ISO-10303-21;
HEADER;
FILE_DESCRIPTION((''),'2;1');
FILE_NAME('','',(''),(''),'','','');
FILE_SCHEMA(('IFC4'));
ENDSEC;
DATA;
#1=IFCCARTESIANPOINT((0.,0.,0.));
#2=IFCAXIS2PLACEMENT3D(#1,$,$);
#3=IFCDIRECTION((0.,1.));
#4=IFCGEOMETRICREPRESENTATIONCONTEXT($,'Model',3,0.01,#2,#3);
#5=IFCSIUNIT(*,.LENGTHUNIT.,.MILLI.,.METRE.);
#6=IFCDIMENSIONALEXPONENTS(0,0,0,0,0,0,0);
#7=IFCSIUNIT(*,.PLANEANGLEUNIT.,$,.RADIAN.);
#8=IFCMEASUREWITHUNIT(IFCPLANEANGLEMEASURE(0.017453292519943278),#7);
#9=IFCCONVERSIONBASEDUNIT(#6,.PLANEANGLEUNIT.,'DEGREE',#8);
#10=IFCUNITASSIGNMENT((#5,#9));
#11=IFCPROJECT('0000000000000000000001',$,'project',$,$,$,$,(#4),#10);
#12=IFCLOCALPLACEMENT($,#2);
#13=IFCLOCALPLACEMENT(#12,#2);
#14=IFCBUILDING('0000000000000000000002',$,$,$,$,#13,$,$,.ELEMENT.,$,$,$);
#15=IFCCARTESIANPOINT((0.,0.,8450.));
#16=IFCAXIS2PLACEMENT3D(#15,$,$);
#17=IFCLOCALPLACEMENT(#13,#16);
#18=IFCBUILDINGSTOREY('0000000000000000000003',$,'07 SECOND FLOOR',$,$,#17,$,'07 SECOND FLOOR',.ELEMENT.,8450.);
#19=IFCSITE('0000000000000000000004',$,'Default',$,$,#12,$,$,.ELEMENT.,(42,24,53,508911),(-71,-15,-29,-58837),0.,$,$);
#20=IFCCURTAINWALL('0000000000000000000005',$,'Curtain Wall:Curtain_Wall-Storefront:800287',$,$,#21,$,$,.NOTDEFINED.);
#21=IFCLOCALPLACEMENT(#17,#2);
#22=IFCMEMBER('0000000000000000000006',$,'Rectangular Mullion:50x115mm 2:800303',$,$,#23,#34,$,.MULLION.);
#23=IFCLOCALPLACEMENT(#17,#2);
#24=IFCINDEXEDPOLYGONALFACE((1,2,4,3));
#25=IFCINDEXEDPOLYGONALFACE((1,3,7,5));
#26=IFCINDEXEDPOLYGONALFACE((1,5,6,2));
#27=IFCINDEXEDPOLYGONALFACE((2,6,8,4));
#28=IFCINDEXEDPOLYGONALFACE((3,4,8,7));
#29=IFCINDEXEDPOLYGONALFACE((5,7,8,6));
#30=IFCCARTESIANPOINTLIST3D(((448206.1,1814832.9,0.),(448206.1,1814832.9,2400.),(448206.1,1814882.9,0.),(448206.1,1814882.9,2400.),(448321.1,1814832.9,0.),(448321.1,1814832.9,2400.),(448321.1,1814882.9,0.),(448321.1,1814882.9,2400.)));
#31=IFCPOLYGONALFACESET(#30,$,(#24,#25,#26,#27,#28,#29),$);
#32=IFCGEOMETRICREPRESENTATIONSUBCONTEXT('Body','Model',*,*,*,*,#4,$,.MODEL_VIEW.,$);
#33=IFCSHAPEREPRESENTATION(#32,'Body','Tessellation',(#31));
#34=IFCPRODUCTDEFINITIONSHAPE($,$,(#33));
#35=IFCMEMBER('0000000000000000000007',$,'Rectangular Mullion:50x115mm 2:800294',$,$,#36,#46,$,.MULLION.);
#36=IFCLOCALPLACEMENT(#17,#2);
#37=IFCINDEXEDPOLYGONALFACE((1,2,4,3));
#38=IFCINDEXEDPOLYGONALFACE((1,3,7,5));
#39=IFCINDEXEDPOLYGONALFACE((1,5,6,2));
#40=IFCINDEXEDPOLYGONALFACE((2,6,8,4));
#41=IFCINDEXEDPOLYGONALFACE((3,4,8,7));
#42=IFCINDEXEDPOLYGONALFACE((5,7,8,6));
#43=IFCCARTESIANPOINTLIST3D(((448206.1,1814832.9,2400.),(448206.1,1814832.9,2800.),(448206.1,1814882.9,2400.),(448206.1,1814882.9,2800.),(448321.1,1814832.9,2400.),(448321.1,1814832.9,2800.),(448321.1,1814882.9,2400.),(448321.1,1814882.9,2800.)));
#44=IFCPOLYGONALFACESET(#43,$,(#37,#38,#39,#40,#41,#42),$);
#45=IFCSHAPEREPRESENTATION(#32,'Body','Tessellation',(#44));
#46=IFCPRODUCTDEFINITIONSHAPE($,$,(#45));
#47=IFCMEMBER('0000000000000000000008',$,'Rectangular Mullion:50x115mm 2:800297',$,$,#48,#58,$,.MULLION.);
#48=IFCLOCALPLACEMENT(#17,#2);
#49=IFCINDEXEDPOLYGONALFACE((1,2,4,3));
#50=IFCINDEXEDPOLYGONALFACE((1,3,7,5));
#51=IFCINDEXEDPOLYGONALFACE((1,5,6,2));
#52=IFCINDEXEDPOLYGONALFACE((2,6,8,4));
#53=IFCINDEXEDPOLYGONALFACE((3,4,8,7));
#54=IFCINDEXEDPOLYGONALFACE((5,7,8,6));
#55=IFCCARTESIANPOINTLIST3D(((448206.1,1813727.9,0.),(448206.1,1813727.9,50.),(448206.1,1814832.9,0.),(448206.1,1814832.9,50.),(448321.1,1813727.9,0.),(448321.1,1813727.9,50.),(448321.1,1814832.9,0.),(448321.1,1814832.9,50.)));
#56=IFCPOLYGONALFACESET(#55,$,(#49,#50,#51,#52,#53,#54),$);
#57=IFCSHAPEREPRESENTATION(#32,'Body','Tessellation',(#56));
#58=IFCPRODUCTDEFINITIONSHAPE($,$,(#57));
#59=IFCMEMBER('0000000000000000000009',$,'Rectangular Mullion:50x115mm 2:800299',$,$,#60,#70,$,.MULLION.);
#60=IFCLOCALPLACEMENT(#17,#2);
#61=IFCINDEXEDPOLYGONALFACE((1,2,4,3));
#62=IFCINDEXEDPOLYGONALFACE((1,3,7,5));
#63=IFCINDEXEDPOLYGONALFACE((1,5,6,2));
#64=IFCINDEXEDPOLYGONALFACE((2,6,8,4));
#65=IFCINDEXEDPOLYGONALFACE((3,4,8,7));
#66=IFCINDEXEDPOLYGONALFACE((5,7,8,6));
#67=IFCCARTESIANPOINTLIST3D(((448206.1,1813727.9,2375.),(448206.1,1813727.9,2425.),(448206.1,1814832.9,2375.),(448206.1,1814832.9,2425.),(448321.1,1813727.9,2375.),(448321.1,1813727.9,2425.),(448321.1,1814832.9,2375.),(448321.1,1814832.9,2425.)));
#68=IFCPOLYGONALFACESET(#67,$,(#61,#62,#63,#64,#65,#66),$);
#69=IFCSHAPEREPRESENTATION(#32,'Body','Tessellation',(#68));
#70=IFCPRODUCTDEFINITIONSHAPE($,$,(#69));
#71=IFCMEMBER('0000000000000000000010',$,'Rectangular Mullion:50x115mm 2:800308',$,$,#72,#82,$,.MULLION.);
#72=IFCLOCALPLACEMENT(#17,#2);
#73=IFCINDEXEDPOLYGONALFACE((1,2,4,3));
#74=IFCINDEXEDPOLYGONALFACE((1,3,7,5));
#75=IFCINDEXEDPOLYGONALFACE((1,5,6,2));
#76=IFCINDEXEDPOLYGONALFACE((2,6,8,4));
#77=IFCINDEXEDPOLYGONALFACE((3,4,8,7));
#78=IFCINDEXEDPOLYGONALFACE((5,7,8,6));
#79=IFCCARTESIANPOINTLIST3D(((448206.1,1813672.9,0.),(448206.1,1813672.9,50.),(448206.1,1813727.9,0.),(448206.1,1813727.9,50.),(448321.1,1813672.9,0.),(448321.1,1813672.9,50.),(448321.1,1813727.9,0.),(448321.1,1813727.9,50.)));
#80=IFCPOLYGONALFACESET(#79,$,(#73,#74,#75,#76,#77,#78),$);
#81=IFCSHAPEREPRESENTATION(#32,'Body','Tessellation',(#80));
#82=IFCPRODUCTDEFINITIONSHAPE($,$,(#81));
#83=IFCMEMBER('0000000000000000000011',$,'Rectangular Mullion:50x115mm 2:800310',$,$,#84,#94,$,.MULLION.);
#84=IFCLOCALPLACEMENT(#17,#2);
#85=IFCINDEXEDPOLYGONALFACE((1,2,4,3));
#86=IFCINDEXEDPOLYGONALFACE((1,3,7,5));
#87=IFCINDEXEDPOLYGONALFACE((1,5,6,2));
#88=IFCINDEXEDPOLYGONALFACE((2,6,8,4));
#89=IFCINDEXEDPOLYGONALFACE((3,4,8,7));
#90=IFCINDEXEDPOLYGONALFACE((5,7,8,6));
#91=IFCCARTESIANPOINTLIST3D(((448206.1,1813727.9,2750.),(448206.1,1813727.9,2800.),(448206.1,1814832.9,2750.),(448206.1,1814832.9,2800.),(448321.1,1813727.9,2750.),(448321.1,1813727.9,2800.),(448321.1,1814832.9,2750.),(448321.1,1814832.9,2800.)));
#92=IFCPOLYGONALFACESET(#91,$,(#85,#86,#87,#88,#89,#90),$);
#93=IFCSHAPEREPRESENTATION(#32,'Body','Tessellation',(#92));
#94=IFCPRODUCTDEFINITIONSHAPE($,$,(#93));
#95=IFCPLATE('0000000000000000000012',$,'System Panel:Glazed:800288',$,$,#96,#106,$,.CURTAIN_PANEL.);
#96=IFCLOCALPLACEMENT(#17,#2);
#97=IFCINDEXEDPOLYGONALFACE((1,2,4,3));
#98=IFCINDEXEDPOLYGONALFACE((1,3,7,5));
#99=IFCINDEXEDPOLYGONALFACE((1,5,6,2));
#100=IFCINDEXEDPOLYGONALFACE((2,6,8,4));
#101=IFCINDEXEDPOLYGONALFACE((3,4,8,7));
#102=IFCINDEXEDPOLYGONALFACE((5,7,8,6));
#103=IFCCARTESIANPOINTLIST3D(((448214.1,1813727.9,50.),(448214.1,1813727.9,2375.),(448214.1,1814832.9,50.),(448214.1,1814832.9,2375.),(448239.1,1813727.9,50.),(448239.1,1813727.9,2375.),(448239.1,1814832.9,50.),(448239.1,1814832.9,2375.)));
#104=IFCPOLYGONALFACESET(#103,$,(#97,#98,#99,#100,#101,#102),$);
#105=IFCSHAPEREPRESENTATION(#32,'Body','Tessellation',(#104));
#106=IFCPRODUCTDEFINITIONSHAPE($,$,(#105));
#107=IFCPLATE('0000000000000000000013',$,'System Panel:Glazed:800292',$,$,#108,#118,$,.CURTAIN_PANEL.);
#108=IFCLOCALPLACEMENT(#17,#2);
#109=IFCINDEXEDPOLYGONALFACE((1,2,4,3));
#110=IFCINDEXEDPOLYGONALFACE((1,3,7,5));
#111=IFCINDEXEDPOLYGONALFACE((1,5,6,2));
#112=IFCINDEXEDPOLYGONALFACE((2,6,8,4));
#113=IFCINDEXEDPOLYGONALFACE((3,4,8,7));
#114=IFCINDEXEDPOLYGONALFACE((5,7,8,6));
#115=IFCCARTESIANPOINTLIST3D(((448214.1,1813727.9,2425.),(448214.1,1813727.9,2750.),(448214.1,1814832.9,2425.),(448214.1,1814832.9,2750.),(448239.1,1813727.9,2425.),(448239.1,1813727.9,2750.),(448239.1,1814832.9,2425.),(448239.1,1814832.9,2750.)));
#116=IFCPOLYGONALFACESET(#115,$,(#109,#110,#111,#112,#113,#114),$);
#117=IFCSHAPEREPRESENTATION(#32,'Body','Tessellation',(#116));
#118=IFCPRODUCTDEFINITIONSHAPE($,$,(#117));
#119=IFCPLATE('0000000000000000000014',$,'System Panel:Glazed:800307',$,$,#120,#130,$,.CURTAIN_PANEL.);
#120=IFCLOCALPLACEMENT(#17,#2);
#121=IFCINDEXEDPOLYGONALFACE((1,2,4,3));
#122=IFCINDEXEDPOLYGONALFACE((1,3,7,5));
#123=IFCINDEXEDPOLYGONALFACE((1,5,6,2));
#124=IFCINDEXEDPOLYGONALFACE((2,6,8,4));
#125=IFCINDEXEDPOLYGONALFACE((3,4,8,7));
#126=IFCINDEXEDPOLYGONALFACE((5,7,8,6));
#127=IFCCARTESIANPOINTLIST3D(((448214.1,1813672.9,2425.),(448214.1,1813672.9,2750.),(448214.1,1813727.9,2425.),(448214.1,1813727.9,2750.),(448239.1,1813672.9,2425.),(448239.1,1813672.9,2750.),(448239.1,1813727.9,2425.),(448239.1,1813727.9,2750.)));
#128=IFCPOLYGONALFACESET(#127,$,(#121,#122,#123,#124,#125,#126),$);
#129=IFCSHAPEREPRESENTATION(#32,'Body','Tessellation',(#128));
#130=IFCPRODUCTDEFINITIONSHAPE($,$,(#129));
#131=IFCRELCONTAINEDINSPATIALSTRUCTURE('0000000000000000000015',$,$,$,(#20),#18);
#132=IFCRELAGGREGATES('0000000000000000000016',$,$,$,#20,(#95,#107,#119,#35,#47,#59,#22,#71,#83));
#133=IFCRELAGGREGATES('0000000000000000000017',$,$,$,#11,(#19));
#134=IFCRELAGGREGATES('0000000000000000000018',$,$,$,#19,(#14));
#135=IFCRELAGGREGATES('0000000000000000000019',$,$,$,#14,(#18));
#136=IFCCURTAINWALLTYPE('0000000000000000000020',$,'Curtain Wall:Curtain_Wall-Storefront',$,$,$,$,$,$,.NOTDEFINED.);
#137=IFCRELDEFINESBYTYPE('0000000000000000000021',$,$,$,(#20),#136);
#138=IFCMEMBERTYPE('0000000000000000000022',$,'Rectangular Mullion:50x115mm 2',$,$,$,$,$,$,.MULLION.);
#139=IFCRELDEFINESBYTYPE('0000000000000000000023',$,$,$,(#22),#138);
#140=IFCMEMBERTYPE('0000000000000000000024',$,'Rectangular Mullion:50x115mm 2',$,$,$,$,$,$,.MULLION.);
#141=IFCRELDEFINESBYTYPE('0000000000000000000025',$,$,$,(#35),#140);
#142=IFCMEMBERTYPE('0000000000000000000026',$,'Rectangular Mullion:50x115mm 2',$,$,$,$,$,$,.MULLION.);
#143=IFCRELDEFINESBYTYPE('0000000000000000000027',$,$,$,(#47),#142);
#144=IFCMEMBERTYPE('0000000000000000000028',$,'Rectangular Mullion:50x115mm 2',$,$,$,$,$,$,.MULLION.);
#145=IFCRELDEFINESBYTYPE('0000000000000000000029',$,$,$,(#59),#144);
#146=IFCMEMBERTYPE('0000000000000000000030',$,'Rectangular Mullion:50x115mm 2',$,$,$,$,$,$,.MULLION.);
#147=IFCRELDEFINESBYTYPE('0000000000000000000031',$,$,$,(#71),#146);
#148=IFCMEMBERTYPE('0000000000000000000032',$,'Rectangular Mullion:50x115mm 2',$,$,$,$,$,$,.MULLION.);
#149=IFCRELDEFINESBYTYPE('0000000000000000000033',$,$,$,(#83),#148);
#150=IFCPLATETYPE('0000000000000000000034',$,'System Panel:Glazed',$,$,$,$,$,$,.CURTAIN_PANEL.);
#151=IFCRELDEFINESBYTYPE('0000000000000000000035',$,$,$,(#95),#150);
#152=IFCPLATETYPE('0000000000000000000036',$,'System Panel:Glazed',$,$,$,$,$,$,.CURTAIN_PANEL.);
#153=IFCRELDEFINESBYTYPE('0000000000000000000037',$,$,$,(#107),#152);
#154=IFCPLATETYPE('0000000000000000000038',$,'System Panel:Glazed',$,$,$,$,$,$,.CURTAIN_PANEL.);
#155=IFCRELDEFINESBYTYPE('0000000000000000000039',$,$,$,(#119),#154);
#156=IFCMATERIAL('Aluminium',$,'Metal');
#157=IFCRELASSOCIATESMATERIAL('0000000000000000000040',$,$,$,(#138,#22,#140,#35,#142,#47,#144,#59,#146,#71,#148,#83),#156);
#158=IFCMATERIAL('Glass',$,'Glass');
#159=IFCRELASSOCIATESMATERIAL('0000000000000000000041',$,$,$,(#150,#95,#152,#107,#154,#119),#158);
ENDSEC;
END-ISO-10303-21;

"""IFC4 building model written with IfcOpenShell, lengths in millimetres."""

from ifc_helpers import new_model, entity, si_unit, converted_unit, direction, frame, origin, place, context, subcontext, project, spatial, indexed_curve, outline, extrude, source, transform, mapped, material, type_object, type_shapes, element, aggregate, save


model = new_model("IFC4")

# Units and contexts
model_context = context("Model", 3, precision=0.01, world=origin(), true_north=direction((0.0, 1.0)))
body_context = subcontext(model_context, "Body", "Model", "MODEL_VIEW")
ifc_project = project(units=[si_unit("LENGTHUNIT", "METRE", prefix="MILLI"), converted_unit("PLANEANGLEUNIT", "DEGREE", entity("IfcPlaneAngleMeasure", 0.017453292519943278), si_unit("PLANEANGLEUNIT", "RADIAN"), dimensions=[0, 0, 0, 0, 0, 0, 0])], contexts=[model_context])

# Site, building, storey
site_placement = place(None, origin())
site = spatial("IfcSite", under=ifc_project, at=site_placement, Name="Default", CompositionType="ELEMENT", RefLatitude=(42, 24, 53, 508911), RefLongitude=(-71, -15, -29, -58837), RefElevation=0.0)
building_placement = place(site_placement, origin())
building = spatial("IfcBuilding", under=site, at=building_placement, CompositionType="ELEMENT")
storey_placement = place(building_placement, frame((0.0, 0.0, 8450.0)))
storey = spatial("IfcBuildingStorey", under=building, at=storey_placement, Name="07 SECOND FLOOR", LongName="07 SECOND FLOOR", CompositionType="ELEMENT", Elevation=8450.0)

# Curtain wall, members, plates
curtain_wall_type = type_object("IfcCurtainWallType", Name="Curtain Wall:Curtain_Wall-Storefront", PredefinedType="NOTDEFINED")
curtain_wall_placement = place(storey_placement, frame((0.0, 0.0, -8450.0)))
curtain_wall = element("IfcCurtainWall", 1, at=curtain_wall_placement, inside=storey, type_object=curtain_wall_type, Name="Curtain Wall:Curtain_Wall-Storefront:800287", PredefinedType="NOTDEFINED")
ifc_material_1 = material(Name="Aluminium", Category="Metal")
member_type_1 = type_object("IfcMemberType", Name="Rectangular Mullion:50x115mm 2", PredefinedType="MULLION", material=ifc_material_1)
shared_shape_1 = source(origin(), body_context, "Body", "SweptSolid", [
    extrude(outline(indexed_curve([(-25.0, -57.5), (25.0, -57.5), (25.0, 57.5), (-25.0, 57.5), (-25.0, -57.5)], self_intersect=False)), frame((-25.0, 0.0, -2400.0), z_axis=(0.0, 0.0, 1.0), x_axis=(-1.0, 0.0, 0.0)), (0.0, 0.0, 1.0), 2400.0),
])
type_shapes(member_type_1, [shared_shape_1])
member_1_placement = place(curtain_wall_placement, frame((448263.6, 1814882.9, 10850.0), z_axis=(0.0, 0.0, 1.0), x_axis=(0.0, 1.0, 0.0)))
member_1 = element("IfcMember", 2, at=member_1_placement, type_object=member_type_1, material=ifc_material_1, Name="Rectangular Mullion:50x115mm 2:800303", PredefinedType="MULLION", context=body_context, shape_type="MappedRepresentation", body=[
    mapped(shared_shape_1, transform((0.0, 0.0, 0.0), scale=1.0)),
])
member_type_2 = type_object("IfcMemberType", Name="Rectangular Mullion:50x115mm 2", PredefinedType="MULLION", material=ifc_material_1)
shared_shape_2 = source(origin(), body_context, "Body", "SweptSolid", [
    extrude(outline(indexed_curve([(-25.0, -57.5), (25.0, -57.5), (25.0, 57.5), (-25.0, 57.5), (-25.0, -57.5)], self_intersect=False)), frame((-25.0, 0.0, -400.0), z_axis=(0.0, 0.0, 1.0), x_axis=(-1.0, 0.0, 0.0)), (0.0, 0.0, 1.0), 400.0),
])
type_shapes(member_type_2, [shared_shape_2])
member_2_placement = place(curtain_wall_placement, frame((448263.6, 1814882.9, 11250.0), z_axis=(0.0, 0.0, 1.0), x_axis=(0.0, 1.0, 0.0)))
member_2 = element("IfcMember", 3, at=member_2_placement, type_object=member_type_2, material=ifc_material_1, Name="Rectangular Mullion:50x115mm 2:800294", PredefinedType="MULLION", context=body_context, shape_type="MappedRepresentation", body=[
    mapped(shared_shape_2, transform((0.0, 0.0, 0.0), scale=1.0)),
])
member_type_3 = type_object("IfcMemberType", Name="Rectangular Mullion:50x115mm 2", PredefinedType="MULLION", material=ifc_material_1)
shared_shape_3 = source(origin(), body_context, "Body", "SweptSolid", [
    extrude(outline(indexed_curve([(-25.0, -57.5), (25.0, -57.5), (25.0, 57.5), (-25.0, 57.5), (-25.0, -57.5)], self_intersect=False)), frame((-25.0, 0.0, -1105.0), z_axis=(0.0, 0.0, 1.0), x_axis=(-1.0, 0.0, 0.0)), (0.0, 0.0, 1.0), 1105.0),
])
type_shapes(member_type_3, [shared_shape_3])
member_3_placement = place(curtain_wall_placement, frame((448263.6, 1814832.9, 8450.0), z_axis=(0.0, 1.0, 0.0), x_axis=(0.0, 0.0, -1.0)))
member_3 = element("IfcMember", 4, at=member_3_placement, type_object=member_type_3, material=ifc_material_1, Name="Rectangular Mullion:50x115mm 2:800297", PredefinedType="MULLION", context=body_context, shape_type="MappedRepresentation", body=[
    mapped(shared_shape_3, transform((0.0, 0.0, 0.0), scale=1.0)),
])
member_type_4 = type_object("IfcMemberType", Name="Rectangular Mullion:50x115mm 2", PredefinedType="MULLION", material=ifc_material_1)
shared_shape_4 = source(origin(), body_context, "Body", "SweptSolid", [
    extrude(outline(indexed_curve([(-25.0, -57.5), (25.0, -57.5), (25.0, 57.5), (-25.0, 57.5), (-25.0, -57.5)], self_intersect=False)), frame((0.0, 0.0, -1105.0), z_axis=(0.0, 0.0, 1.0), x_axis=(-1.0, 0.0, 0.0)), (0.0, 0.0, 1.0), 1105.0),
])
type_shapes(member_type_4, [shared_shape_4])
member_4_placement = place(curtain_wall_placement, frame((448263.6, 1813727.9, 10850.0), z_axis=(0.0, -1.0, 0.0), x_axis=(0.0, 0.0, 1.0)))
member_4 = element("IfcMember", 5, at=member_4_placement, type_object=member_type_4, material=ifc_material_1, Name="Rectangular Mullion:50x115mm 2:800299", PredefinedType="MULLION", context=body_context, shape_type="MappedRepresentation", body=[
    mapped(shared_shape_4, transform((0.0, 0.0, 0.0), scale=1.0)),
])
member_type_5 = type_object("IfcMemberType", Name="Rectangular Mullion:50x115mm 2", PredefinedType="MULLION", material=ifc_material_1)
shared_shape_5 = source(origin(), body_context, "Body", "SweptSolid", [
    extrude(outline(indexed_curve([(-25.0, -57.5), (25.0, -57.5), (25.0, 57.5), (-25.0, 57.5), (-25.0, -57.5)], self_intersect=False)), frame((-25.0, 0.0, -55.0), z_axis=(0.0, 0.0, 1.0), x_axis=(-1.0, 0.0, 0.0)), (0.0, 0.0, 1.0), 55.0),
])
type_shapes(member_type_5, [shared_shape_5])
member_5_placement = place(curtain_wall_placement, frame((448263.6, 1813727.9, 8450.0), z_axis=(0.0, 1.0, 0.0), x_axis=(0.0, 0.0, -1.0)))
member_5 = element("IfcMember", 6, at=member_5_placement, type_object=member_type_5, material=ifc_material_1, Name="Rectangular Mullion:50x115mm 2:800308", PredefinedType="MULLION", context=body_context, shape_type="MappedRepresentation", body=[
    mapped(shared_shape_5, transform((0.0, 0.0, 0.0), scale=1.0)),
])
member_type_6 = type_object("IfcMemberType", Name="Rectangular Mullion:50x115mm 2", PredefinedType="MULLION", material=ifc_material_1)
shared_shape_6 = source(origin(), body_context, "Body", "SweptSolid", [
    extrude(outline(indexed_curve([(-25.0, -57.5), (25.0, -57.5), (25.0, 57.5), (-25.0, 57.5), (-25.0, -57.5)], self_intersect=False)), frame((-25.0, 0.0, -1105.0), z_axis=(0.0, 0.0, 1.0), x_axis=(-1.0, 0.0, 0.0)), (0.0, 0.0, 1.0), 1105.0),
])
type_shapes(member_type_6, [shared_shape_6])
member_6_placement = place(curtain_wall_placement, frame((448263.6, 1813727.9, 11250.0), z_axis=(0.0, -1.0, 0.0), x_axis=(0.0, 0.0, 1.0)))
member_6 = element("IfcMember", 7, at=member_6_placement, type_object=member_type_6, material=ifc_material_1, Name="Rectangular Mullion:50x115mm 2:800310", PredefinedType="MULLION", context=body_context, shape_type="MappedRepresentation", body=[
    mapped(shared_shape_6, transform((0.0, 0.0, 0.0), scale=1.0)),
])
ifc_material_2 = material(Name="Glass", Category="Glass")
plate_type_1 = type_object("IfcPlateType", Name="System Panel:Glazed", PredefinedType="CURTAIN_PANEL", material=ifc_material_2)
shared_shape_7 = source(origin(), body_context, "Body", "SweptSolid", [
    extrude(outline(indexed_curve([(-12.5, -552.5), (12.5, -552.5), (12.5, 552.5), (-12.5, 552.5), (-12.5, -552.5)], self_intersect=False)), frame((0.0, -37.0, 0.0), z_axis=(0.0, 0.0, 1.0), x_axis=(0.0, 1.0, 0.0)), (0.0, 0.0, 1.0), 2325.0),
])
type_shapes(plate_type_1, [shared_shape_7])
plate_1_placement = place(curtain_wall_placement, frame((448263.6, 1814280.4, 8500.0), z_axis=(0.0, 0.0, 1.0), x_axis=(0.0, -1.0, 0.0)))
plate_1 = element("IfcPlate", 8, at=plate_1_placement, type_object=plate_type_1, material=ifc_material_2, Name="System Panel:Glazed:800288", PredefinedType="CURTAIN_PANEL", context=body_context, shape_type="MappedRepresentation", body=[
    mapped(shared_shape_7, transform((0.0, 0.0, 0.0), scale=1.0)),
])
plate_type_2 = type_object("IfcPlateType", Name="System Panel:Glazed", PredefinedType="CURTAIN_PANEL", material=ifc_material_2)
shared_shape_8 = source(origin(), body_context, "Body", "SweptSolid", [
    extrude(outline(indexed_curve([(-12.5, -552.5), (12.5, -552.5), (12.5, 552.5), (-12.5, 552.5), (-12.5, -552.5)], self_intersect=False)), frame((0.0, -37.0, 0.0), z_axis=(0.0, 0.0, 1.0), x_axis=(0.0, 1.0, 0.0)), (0.0, 0.0, 1.0), 325.0),
])
type_shapes(plate_type_2, [shared_shape_8])
plate_2_placement = place(curtain_wall_placement, frame((448263.6, 1814280.4, 10875.0), z_axis=(0.0, 0.0, 1.0), x_axis=(0.0, -1.0, 0.0)))
plate_2 = element("IfcPlate", 9, at=plate_2_placement, type_object=plate_type_2, material=ifc_material_2, Name="System Panel:Glazed:800292", PredefinedType="CURTAIN_PANEL", context=body_context, shape_type="MappedRepresentation", body=[
    mapped(shared_shape_8, transform((0.0, 0.0, 0.0), scale=1.0)),
])
plate_type_3 = type_object("IfcPlateType", Name="System Panel:Glazed", PredefinedType="CURTAIN_PANEL", material=ifc_material_2)
shared_shape_9 = source(origin(), body_context, "Body", "SweptSolid", [
    extrude(outline(indexed_curve([(-12.5, -27.5), (12.5, -27.5), (12.5, 27.5), (-12.5, 27.5), (-12.5, -27.5)], self_intersect=False)), frame((0.0, -37.0, 0.0), z_axis=(0.0, 0.0, 1.0), x_axis=(0.0, 1.0, 0.0)), (0.0, 0.0, 1.0), 325.0),
])
type_shapes(plate_type_3, [shared_shape_9])
plate_3_placement = place(curtain_wall_placement, frame((448263.6, 1813700.4, 10875.0), z_axis=(0.0, 0.0, 1.0), x_axis=(0.0, -1.0, 0.0)))
plate_3 = element("IfcPlate", 10, at=plate_3_placement, type_object=plate_type_3, material=ifc_material_2, Name="System Panel:Glazed:800307", PredefinedType="CURTAIN_PANEL", context=body_context, shape_type="MappedRepresentation", body=[
    mapped(shared_shape_9, transform((0.0, 0.0, 0.0), scale=1.0)),
])
aggregate(curtain_wall, [plate_1, plate_2, plate_3, member_2, member_3, member_4, member_1, member_5, member_6])

save(model, "model.ifc")
